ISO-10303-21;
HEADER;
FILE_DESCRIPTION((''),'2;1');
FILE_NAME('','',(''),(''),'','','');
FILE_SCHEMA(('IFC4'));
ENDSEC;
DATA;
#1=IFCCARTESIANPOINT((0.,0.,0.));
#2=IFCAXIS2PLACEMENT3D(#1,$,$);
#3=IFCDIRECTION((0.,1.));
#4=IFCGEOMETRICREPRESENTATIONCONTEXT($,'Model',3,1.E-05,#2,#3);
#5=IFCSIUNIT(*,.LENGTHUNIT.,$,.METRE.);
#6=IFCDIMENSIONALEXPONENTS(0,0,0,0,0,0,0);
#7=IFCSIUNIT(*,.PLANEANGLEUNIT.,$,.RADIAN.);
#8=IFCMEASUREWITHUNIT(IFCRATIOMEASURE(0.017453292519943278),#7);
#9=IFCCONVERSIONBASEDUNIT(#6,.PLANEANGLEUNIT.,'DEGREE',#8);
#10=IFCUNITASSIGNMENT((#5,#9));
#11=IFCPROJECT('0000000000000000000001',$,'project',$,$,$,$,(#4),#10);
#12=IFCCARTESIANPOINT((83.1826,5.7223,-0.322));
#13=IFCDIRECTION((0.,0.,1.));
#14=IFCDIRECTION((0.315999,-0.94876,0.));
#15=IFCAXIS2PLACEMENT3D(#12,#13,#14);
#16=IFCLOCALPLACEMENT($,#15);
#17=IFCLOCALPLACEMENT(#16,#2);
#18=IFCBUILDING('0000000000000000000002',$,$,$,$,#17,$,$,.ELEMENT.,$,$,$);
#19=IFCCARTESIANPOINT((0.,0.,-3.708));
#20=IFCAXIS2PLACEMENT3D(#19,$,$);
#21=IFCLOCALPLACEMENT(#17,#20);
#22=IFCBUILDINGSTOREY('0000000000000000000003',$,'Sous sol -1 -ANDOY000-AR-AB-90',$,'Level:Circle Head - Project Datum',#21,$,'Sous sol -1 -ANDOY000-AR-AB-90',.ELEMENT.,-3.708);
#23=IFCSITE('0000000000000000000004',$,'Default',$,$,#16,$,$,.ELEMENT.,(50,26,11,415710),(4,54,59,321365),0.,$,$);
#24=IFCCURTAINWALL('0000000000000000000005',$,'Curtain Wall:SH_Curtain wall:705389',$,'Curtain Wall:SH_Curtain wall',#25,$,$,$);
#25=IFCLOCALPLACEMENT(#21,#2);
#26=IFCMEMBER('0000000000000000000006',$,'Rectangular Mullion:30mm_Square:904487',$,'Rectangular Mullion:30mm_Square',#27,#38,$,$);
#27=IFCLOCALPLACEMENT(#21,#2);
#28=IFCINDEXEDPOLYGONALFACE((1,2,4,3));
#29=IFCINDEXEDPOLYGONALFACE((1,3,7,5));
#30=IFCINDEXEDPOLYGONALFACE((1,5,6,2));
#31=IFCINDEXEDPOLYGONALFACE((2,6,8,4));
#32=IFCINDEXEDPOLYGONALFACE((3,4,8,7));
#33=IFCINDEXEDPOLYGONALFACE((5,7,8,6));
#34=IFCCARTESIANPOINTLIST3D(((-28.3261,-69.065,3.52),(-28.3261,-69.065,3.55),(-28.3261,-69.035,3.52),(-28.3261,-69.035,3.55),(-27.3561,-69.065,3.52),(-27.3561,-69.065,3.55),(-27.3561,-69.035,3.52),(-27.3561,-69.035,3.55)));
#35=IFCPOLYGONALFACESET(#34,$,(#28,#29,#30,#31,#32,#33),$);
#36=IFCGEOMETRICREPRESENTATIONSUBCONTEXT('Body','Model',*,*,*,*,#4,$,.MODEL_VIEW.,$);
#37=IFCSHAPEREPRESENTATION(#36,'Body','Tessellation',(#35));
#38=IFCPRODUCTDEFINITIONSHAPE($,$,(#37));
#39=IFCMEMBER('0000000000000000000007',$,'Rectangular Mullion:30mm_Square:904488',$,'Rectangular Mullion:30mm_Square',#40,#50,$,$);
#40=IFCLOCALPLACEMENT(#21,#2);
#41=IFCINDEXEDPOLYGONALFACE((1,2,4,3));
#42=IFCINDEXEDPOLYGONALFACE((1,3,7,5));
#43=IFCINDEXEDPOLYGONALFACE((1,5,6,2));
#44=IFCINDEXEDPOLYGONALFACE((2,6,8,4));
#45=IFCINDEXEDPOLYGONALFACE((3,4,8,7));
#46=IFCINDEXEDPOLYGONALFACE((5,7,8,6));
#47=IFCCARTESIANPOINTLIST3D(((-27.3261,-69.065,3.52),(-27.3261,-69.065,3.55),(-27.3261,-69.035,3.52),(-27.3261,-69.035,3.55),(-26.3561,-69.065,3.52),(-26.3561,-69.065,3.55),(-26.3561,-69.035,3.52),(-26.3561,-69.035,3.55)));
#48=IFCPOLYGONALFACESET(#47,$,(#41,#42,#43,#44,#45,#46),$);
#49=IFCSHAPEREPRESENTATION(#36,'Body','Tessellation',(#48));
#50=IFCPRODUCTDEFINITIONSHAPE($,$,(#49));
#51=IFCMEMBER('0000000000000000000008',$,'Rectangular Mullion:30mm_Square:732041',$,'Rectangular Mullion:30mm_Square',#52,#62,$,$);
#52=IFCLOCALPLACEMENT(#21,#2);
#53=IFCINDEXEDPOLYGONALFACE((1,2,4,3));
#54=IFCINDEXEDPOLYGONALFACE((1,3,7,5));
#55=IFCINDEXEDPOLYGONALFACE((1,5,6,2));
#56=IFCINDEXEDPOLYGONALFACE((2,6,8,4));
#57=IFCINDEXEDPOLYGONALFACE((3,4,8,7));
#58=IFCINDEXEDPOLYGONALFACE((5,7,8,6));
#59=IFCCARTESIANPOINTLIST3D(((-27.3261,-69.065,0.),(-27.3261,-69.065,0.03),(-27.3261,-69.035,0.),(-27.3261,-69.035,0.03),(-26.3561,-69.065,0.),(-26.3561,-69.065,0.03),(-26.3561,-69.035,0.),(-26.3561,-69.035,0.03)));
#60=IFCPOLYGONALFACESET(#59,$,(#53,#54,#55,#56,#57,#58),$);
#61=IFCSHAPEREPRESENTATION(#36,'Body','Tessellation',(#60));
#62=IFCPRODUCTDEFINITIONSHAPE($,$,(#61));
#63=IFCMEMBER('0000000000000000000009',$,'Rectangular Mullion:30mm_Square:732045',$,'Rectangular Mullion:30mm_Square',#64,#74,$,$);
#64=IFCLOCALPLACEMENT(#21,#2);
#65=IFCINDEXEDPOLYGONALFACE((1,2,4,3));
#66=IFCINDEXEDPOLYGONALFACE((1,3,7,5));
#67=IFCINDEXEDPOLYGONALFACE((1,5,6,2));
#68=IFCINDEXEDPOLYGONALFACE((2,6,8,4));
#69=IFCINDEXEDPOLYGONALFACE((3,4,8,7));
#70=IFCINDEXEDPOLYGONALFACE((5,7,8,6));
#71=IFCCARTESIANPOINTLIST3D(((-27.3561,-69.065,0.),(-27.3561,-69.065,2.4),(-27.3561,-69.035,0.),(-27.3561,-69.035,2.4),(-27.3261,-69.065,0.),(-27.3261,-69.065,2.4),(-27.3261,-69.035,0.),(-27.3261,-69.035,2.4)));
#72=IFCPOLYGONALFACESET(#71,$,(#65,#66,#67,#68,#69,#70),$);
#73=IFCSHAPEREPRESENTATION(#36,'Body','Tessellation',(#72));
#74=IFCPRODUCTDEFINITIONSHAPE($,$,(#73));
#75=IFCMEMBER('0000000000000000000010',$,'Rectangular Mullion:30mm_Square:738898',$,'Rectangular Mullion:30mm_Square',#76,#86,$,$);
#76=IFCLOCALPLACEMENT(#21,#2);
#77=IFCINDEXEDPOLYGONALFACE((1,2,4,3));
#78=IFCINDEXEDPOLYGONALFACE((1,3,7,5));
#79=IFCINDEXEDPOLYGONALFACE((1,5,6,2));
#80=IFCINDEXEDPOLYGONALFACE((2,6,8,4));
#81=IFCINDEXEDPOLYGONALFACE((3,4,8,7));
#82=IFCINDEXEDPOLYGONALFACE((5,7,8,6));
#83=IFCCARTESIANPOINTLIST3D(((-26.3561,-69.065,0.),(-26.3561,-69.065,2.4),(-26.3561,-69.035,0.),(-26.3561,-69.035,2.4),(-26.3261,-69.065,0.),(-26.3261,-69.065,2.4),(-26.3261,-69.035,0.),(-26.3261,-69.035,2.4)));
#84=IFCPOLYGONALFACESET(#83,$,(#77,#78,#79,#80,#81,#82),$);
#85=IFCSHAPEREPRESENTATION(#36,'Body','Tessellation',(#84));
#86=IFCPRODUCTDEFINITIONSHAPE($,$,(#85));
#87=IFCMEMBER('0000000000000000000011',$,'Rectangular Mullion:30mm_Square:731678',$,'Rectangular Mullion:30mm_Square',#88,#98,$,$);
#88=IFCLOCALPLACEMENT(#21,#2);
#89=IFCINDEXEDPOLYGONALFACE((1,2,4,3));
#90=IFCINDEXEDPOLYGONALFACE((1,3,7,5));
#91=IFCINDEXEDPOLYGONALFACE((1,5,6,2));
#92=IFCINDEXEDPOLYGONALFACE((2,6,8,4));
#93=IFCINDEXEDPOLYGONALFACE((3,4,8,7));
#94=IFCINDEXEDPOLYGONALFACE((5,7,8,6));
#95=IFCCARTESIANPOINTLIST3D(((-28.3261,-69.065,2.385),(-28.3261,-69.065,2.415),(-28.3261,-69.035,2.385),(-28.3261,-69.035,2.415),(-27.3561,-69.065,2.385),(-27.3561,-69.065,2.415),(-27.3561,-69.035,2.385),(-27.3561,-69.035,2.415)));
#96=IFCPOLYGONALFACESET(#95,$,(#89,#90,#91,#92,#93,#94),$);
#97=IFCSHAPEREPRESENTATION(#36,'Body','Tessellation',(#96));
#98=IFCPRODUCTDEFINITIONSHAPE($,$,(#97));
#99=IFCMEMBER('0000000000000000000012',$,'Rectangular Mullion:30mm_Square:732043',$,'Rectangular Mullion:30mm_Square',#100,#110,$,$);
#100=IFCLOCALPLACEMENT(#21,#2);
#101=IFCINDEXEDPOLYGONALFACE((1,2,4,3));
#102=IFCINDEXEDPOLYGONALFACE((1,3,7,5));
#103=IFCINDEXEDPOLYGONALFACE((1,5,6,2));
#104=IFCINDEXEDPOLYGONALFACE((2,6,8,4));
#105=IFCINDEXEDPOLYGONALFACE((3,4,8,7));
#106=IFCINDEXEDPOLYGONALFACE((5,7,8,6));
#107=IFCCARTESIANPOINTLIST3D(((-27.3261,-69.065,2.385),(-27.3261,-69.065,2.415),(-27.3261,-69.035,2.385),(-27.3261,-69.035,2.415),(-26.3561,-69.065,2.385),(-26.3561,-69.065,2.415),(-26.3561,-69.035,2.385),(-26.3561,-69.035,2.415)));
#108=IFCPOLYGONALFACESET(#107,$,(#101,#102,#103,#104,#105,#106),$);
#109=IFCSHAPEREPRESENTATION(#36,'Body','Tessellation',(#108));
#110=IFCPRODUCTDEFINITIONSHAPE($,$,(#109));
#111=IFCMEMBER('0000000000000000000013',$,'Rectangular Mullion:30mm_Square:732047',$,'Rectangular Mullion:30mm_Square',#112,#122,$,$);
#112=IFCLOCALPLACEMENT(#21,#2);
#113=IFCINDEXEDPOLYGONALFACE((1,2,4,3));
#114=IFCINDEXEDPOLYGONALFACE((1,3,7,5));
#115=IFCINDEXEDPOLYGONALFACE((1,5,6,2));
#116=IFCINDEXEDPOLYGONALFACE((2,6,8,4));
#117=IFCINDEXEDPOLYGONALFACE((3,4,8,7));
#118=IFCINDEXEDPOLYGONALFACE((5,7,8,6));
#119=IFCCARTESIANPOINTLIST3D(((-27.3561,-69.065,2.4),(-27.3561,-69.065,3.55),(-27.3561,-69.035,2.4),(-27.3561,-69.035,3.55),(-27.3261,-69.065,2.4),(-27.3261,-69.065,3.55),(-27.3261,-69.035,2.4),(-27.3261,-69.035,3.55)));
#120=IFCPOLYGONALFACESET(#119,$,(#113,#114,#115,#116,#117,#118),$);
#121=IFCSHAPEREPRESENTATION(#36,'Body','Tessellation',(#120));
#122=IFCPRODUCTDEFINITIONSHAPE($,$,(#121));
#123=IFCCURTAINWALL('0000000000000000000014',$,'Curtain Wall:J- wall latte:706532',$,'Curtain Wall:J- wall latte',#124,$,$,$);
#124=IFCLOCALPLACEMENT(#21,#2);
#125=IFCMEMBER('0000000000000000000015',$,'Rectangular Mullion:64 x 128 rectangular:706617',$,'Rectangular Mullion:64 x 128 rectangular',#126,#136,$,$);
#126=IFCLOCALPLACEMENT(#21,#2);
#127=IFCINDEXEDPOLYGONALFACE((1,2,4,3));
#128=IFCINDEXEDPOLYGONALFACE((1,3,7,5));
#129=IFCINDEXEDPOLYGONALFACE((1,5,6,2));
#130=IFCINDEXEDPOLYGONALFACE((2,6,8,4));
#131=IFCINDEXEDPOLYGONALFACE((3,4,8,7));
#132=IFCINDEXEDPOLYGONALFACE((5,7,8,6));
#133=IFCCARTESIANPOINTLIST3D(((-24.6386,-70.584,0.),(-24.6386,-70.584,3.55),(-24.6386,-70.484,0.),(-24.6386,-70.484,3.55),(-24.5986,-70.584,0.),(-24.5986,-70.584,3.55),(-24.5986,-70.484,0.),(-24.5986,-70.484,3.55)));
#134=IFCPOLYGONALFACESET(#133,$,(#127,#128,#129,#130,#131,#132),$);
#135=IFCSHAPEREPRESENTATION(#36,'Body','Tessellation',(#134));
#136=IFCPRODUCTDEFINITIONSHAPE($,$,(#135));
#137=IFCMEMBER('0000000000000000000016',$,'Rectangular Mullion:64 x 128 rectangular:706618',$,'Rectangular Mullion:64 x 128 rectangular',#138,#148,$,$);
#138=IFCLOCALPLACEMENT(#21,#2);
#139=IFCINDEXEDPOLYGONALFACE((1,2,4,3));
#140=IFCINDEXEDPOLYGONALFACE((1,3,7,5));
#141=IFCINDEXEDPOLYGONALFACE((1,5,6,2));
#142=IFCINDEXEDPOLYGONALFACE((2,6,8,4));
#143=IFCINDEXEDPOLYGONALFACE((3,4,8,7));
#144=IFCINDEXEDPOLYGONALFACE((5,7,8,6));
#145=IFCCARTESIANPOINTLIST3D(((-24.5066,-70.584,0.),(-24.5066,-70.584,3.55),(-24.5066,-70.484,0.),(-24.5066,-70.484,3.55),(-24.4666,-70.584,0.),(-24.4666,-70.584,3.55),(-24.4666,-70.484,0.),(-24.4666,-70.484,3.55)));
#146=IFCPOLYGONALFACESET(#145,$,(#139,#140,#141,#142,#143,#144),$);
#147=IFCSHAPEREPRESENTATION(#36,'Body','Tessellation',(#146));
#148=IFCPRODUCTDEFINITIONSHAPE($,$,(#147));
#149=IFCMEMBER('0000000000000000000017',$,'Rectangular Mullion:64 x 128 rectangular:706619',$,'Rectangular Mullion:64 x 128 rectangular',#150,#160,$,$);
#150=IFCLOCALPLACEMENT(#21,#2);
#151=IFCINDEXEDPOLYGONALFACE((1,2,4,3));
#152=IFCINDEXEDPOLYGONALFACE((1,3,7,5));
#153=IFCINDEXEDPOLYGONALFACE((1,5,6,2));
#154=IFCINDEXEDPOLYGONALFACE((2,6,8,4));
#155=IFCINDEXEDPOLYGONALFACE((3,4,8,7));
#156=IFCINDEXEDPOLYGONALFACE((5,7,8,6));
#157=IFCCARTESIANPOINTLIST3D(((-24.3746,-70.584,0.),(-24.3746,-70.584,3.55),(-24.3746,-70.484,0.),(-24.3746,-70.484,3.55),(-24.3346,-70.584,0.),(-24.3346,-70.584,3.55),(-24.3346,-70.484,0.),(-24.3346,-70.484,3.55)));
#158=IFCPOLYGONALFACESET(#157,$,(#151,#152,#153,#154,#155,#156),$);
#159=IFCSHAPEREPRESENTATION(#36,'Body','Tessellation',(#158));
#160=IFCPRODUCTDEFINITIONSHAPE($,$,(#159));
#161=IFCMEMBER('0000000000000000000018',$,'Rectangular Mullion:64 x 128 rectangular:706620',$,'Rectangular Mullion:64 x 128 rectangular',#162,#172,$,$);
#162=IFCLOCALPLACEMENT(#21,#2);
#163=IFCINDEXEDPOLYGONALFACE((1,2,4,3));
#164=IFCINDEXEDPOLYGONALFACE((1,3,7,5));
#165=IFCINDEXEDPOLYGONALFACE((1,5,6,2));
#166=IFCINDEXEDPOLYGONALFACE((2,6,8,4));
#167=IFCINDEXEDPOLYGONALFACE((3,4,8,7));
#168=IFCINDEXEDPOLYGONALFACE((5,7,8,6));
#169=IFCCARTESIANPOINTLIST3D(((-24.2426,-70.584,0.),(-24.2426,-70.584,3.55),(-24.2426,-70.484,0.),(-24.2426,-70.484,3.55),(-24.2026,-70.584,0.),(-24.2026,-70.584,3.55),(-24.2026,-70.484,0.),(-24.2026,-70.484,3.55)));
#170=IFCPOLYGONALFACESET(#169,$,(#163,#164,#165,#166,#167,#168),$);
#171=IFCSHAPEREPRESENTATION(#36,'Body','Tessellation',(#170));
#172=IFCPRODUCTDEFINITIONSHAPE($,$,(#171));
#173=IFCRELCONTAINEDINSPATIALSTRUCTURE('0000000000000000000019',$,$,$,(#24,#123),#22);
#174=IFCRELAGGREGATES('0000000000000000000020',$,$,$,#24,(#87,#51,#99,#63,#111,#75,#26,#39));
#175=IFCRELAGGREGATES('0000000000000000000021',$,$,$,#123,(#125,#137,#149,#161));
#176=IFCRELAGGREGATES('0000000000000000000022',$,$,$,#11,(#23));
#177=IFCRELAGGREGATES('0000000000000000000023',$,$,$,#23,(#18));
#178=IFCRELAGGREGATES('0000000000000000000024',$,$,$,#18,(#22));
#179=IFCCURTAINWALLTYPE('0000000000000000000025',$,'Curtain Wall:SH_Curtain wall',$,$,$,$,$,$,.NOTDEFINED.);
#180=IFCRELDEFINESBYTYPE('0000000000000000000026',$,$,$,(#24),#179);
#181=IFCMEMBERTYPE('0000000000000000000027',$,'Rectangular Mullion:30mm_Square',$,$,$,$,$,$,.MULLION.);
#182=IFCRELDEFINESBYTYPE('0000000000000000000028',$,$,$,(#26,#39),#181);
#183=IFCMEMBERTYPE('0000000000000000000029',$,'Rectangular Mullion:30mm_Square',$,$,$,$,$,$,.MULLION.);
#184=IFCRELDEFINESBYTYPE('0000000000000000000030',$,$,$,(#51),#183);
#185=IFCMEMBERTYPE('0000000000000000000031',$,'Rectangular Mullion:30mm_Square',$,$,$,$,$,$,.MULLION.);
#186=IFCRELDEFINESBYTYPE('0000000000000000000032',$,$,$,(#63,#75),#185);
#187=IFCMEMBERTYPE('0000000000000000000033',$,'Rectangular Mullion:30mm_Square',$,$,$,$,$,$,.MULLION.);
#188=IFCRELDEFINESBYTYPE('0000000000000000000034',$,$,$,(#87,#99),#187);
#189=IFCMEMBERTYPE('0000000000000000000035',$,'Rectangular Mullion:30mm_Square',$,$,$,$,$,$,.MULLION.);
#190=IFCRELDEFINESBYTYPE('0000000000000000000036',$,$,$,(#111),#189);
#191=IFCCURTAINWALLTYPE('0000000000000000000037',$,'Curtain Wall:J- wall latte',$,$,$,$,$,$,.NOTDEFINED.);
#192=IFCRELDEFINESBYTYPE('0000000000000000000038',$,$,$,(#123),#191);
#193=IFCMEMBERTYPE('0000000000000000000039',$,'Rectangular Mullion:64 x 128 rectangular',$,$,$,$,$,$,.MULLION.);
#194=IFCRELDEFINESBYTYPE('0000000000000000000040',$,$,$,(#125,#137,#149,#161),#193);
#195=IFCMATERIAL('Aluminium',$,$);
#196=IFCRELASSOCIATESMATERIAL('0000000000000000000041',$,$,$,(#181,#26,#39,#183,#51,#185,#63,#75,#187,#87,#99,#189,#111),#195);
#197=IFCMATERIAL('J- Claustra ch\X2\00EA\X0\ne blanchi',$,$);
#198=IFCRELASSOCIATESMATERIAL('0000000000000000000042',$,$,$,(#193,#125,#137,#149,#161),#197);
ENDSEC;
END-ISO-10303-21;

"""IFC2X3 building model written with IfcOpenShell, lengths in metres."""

from ifc_helpers import new_model, entity, si_unit, converted_unit, direction, frame, origin, origin_2d_with_axis, place, context, subcontext, project, spatial, rectangle, extrude, source, transform, mapped, material, type_object, type_shapes, element, aggregate, save


model = new_model("IFC2X3")

# Units and contexts
model_context = context("Model", 3, precision=1e-05, world=origin(), true_north=direction((0.0, 1.0)))
body_context = subcontext(model_context, "Body", "Model", "MODEL_VIEW")
ifc_project = project(units=[si_unit("LENGTHUNIT", "METRE"), converted_unit("PLANEANGLEUNIT", "DEGREE", entity("IfcRatioMeasure", 0.017453292519943278), si_unit("PLANEANGLEUNIT", "RADIAN"), dimensions=[0, 0, 0, 0, 0, 0, 0])], contexts=[model_context])

# Site, building, storey
site_placement = place(None, frame((83.1826, 5.7223, -0.322), z_axis=(0.0, 0.0, 1.0), x_axis=(0.315999, -0.94876, 0.0)))
site = spatial("IfcSite", under=ifc_project, at=site_placement, Name="Default", CompositionType="ELEMENT", RefLatitude=(50, 26, 11, 415710), RefLongitude=(4, 54, 59, 321365), RefElevation=0.0)
building_placement = place(site_placement, origin())
building = spatial("IfcBuilding", under=site, at=building_placement, CompositionType="ELEMENT")
storey_placement = place(building_placement, frame((0.0, 0.0, -3.708)))
storey = spatial("IfcBuildingStorey", under=building, at=storey_placement, Name="Sous sol -1 -ANDOY000-AR-AB-90", ObjectType="Level:Circle Head - Project Datum", LongName="Sous sol -1 -ANDOY000-AR-AB-90", CompositionType="ELEMENT", Elevation=-3.708)

# Curtain walls, members
curtain_wall_type_1 = type_object("IfcCurtainWallType", Name="Curtain Wall:SH_Curtain wall", PredefinedType="NOTDEFINED")
curtain_wall_1_placement = place(storey_placement, frame((0.0, 0.0, 3.708)))
curtain_wall_1 = element("IfcCurtainWall", 1, at=curtain_wall_1_placement, inside=storey, type_object=curtain_wall_type_1, Name="Curtain Wall:SH_Curtain wall:705389", ObjectType="Curtain Wall:SH_Curtain wall")
ifc_material_1 = material(Name="Aluminium")
member_type_1 = type_object("IfcMemberType", Name="Rectangular Mullion:30mm_Square", PredefinedType="MULLION", material=ifc_material_1)
shared_shape_1 = source(origin(), body_context, "Body", "SweptSolid", [
    extrude(rectangle(XDim=0.03, YDim=0.03, at=origin_2d_with_axis()), frame((-0.015, 0.0, -0.97), z_axis=(0.0, 0.0, 1.0), x_axis=(0.0, -1.0, 0.0)), (0.0, 0.0, 1.0), 0.97),
])
type_shapes(member_type_1, [shared_shape_1])
member_1_placement = place(curtain_wall_1_placement, frame((-27.3561, -69.05, -0.158), z_axis=(1.0, 0.0, 0.0), x_axis=(0.0, 0.0, 1.0)))
member_1 = element("IfcMember", 2, at=member_1_placement, type_object=member_type_1, material=ifc_material_1, Name="Rectangular Mullion:30mm_Square:904487", ObjectType="Rectangular Mullion:30mm_Square", context=body_context, shape_type="MappedRepresentation", body=[
    mapped(shared_shape_1, transform((0.0, 0.0, 0.0), scale=1.0)),
])
member_2_placement = place(curtain_wall_1_placement, frame((-26.3561, -69.05, -0.158), z_axis=(1.0, 0.0, 0.0), x_axis=(0.0, 0.0, 1.0)))
member_2 = element("IfcMember", 3, at=member_2_placement, type_object=member_type_1, material=ifc_material_1, Name="Rectangular Mullion:30mm_Square:904488", ObjectType="Rectangular Mullion:30mm_Square", context=body_context, shape_type="MappedRepresentation", body=[
    mapped(shared_shape_1, transform((0.0, 0.0, 0.0), scale=1.0)),
])
member_type_2 = type_object("IfcMemberType", Name="Rectangular Mullion:30mm_Square", PredefinedType="MULLION", material=ifc_material_1)
shared_shape_2 = source(origin(), body_context, "Body", "SweptSolid", [
    extrude(rectangle(XDim=0.03, YDim=0.03, at=origin_2d_with_axis()), frame((-0.015, 0.0, -0.97), z_axis=(0.0, 0.0, 1.0), x_axis=(0.0, -1.0, 0.0)), (0.0, 0.0, 1.0), 0.97),
])
type_shapes(member_type_2, [shared_shape_2])
member_3_placement = place(curtain_wall_1_placement, frame((-27.3261, -69.05, -3.708), z_axis=(-1.0, 0.0, 0.0), x_axis=(0.0, 0.0, -1.0)))
member_3 = element("IfcMember", 4, at=member_3_placement, type_object=member_type_2, material=ifc_material_1, Name="Rectangular Mullion:30mm_Square:732041", ObjectType="Rectangular Mullion:30mm_Square", context=body_context, shape_type="MappedRepresentation", body=[
    mapped(shared_shape_2, transform((0.0, 0.0, 0.0), scale=1.0)),
])
member_type_3 = type_object("IfcMemberType", Name="Rectangular Mullion:30mm_Square", PredefinedType="MULLION", material=ifc_material_1)
shared_shape_3 = source(origin(), body_context, "Body", "SweptSolid", [
    extrude(rectangle(XDim=0.03, YDim=0.03, at=origin_2d_with_axis()), frame((0.0, 0.0, -2.4), z_axis=(0.0, 0.0, 1.0), x_axis=(0.0, -1.0, 0.0)), (0.0, 0.0, 1.0), 2.4),
])
type_shapes(member_type_3, [shared_shape_3])
member_4_placement = place(curtain_wall_1_placement, frame((-27.3411, -69.05, -3.708), z_axis=(0.0, 0.0, -1.0), x_axis=(1.0, 0.0, 0.0)))
member_4 = element("IfcMember", 5, at=member_4_placement, type_object=member_type_3, material=ifc_material_1, Name="Rectangular Mullion:30mm_Square:732045", ObjectType="Rectangular Mullion:30mm_Square", context=body_context, shape_type="MappedRepresentation", body=[
    mapped(shared_shape_3, transform((0.0, 0.0, 0.0), scale=1.0)),
])
member_5_placement = place(curtain_wall_1_placement, frame((-26.3411, -69.05, -3.708), z_axis=(0.0, 0.0, -1.0), x_axis=(1.0, 0.0, 0.0)))
member_5 = element("IfcMember", 6, at=member_5_placement, type_object=member_type_3, material=ifc_material_1, Name="Rectangular Mullion:30mm_Square:738898", ObjectType="Rectangular Mullion:30mm_Square", context=body_context, shape_type="MappedRepresentation", body=[
    mapped(shared_shape_3, transform((0.0, 0.0, 0.0), scale=1.0)),
])
member_type_4 = type_object("IfcMemberType", Name="Rectangular Mullion:30mm_Square", PredefinedType="MULLION", material=ifc_material_1)
shared_shape_4 = source(origin(), body_context, "Body", "SweptSolid", [
    extrude(rectangle(XDim=0.03, YDim=0.03, at=origin_2d_with_axis()), frame((0.0, 0.0, -0.97), z_axis=(0.0, 0.0, 1.0), x_axis=(0.0, -1.0, 0.0)), (0.0, 0.0, 1.0), 0.97),
])
type_shapes(member_type_4, [shared_shape_4])
member_6_placement = place(curtain_wall_1_placement, frame((-27.3561, -69.05, -1.308), z_axis=(1.0, 0.0, 0.0), x_axis=(0.0, 0.0, 1.0)))
member_6 = element("IfcMember", 7, at=member_6_placement, type_object=member_type_4, material=ifc_material_1, Name="Rectangular Mullion:30mm_Square:731678", ObjectType="Rectangular Mullion:30mm_Square", context=body_context, shape_type="MappedRepresentation", body=[
    mapped(shared_shape_4, transform((0.0, 0.0, 0.0), scale=1.0)),
])
member_7_placement = place(curtain_wall_1_placement, frame((-26.3561, -69.05, -1.308), z_axis=(1.0, 0.0, 0.0), x_axis=(0.0, 0.0, 1.0)))
member_7 = element("IfcMember", 8, at=member_7_placement, type_object=member_type_4, material=ifc_material_1, Name="Rectangular Mullion:30mm_Square:732043", ObjectType="Rectangular Mullion:30mm_Square", context=body_context, shape_type="MappedRepresentation", body=[
    mapped(shared_shape_4, transform((0.0, 0.0, 0.0), scale=1.0)),
])
member_type_5 = type_object("IfcMemberType", Name="Rectangular Mullion:30mm_Square", PredefinedType="MULLION", material=ifc_material_1)
shared_shape_5 = source(origin(), body_context, "Body", "SweptSolid", [
    extrude(rectangle(XDim=0.03, YDim=0.03, at=origin_2d_with_axis()), frame((0.0, 0.0, -1.15), z_axis=(0.0, 0.0, 1.0), x_axis=(0.0, -1.0, 0.0)), (0.0, 0.0, 1.0), 1.15),
])
type_shapes(member_type_5, [shared_shape_5])
member_8_placement = place(curtain_wall_1_placement, frame((-27.3411, -69.05, -1.308), z_axis=(0.0, 0.0, -1.0), x_axis=(1.0, 0.0, 0.0)))
member_8 = element("IfcMember", 9, at=member_8_placement, type_object=member_type_5, material=ifc_material_1, Name="Rectangular Mullion:30mm_Square:732047", ObjectType="Rectangular Mullion:30mm_Square", context=body_context, shape_type="MappedRepresentation", body=[
    mapped(shared_shape_5, transform((0.0, 0.0, 0.0), scale=1.0)),
])
curtain_wall_type_2 = type_object("IfcCurtainWallType", Name="Curtain Wall:J- wall latte", PredefinedType="NOTDEFINED")
curtain_wall_2_placement = place(storey_placement, frame((0.0, 0.0, 3.708)))
curtain_wall_2 = element("IfcCurtainWall", 10, at=curtain_wall_2_placement, inside=storey, type_object=curtain_wall_type_2, Name="Curtain Wall:J- wall latte:706532", ObjectType="Curtain Wall:J- wall latte")
ifc_material_2 = material(Name="J- Claustra chêne blanchi")
member_type_6 = type_object("IfcMemberType", Name="Rectangular Mullion:64 x 128 rectangular", PredefinedType="MULLION", material=ifc_material_2)
shared_shape_6 = source(origin(), body_context, "Body", "SweptSolid", [
    extrude(rectangle(XDim=0.1, YDim=0.04, at=origin_2d_with_axis()), frame((0.0, 0.0, -3.55), z_axis=(0.0, 0.0, 1.0), x_axis=(0.0, -1.0, 0.0)), (0.0, 0.0, 1.0), 3.55),
])
type_shapes(member_type_6, [shared_shape_6])
member_9_placement = place(curtain_wall_2_placement, frame((-24.6186, -70.534, -3.708), z_axis=(0.0, 0.0, -1.0), x_axis=(1.0, 0.0, 0.0)))
member_9 = element("IfcMember", 11, at=member_9_placement, type_object=member_type_6, material=ifc_material_2, Name="Rectangular Mullion:64 x 128 rectangular:706617", ObjectType="Rectangular Mullion:64 x 128 rectangular", context=body_context, shape_type="MappedRepresentation", body=[
    mapped(shared_shape_6, transform((0.0, 0.0, 0.0), scale=1.0)),
])
member_10_placement = place(curtain_wall_2_placement, frame((-24.4866, -70.534, -3.708), z_axis=(0.0, 0.0, -1.0), x_axis=(1.0, 0.0, 0.0)))
member_10 = element("IfcMember", 12, at=member_10_placement, type_object=member_type_6, material=ifc_material_2, Name="Rectangular Mullion:64 x 128 rectangular:706618", ObjectType="Rectangular Mullion:64 x 128 rectangular", context=body_context, shape_type="MappedRepresentation", body=[
    mapped(shared_shape_6, transform((0.0, 0.0, 0.0), scale=1.0)),
])
member_11_placement = place(curtain_wall_2_placement, frame((-24.3546, -70.534, -3.708), z_axis=(0.0, 0.0, -1.0), x_axis=(1.0, 0.0, 0.0)))
member_11 = element("IfcMember", 13, at=member_11_placement, type_object=member_type_6, material=ifc_material_2, Name="Rectangular Mullion:64 x 128 rectangular:706619", ObjectType="Rectangular Mullion:64 x 128 rectangular", context=body_context, shape_type="MappedRepresentation", body=[
    mapped(shared_shape_6, transform((0.0, 0.0, 0.0), scale=1.0)),
])
member_12_placement = place(curtain_wall_2_placement, frame((-24.2226, -70.534, -3.708), z_axis=(0.0, 0.0, -1.0), x_axis=(1.0, 0.0, 0.0)))
member_12 = element("IfcMember", 14, at=member_12_placement, type_object=member_type_6, material=ifc_material_2, Name="Rectangular Mullion:64 x 128 rectangular:706620", ObjectType="Rectangular Mullion:64 x 128 rectangular", context=body_context, shape_type="MappedRepresentation", body=[
    mapped(shared_shape_6, transform((0.0, 0.0, 0.0), scale=1.0)),
])

aggregate(curtain_wall_1, [member_6, member_3, member_7, member_4, member_8, member_5, member_1, member_2])
aggregate(curtain_wall_2, [member_9, member_10, member_11, member_12])

save(model, "model.ifc")
